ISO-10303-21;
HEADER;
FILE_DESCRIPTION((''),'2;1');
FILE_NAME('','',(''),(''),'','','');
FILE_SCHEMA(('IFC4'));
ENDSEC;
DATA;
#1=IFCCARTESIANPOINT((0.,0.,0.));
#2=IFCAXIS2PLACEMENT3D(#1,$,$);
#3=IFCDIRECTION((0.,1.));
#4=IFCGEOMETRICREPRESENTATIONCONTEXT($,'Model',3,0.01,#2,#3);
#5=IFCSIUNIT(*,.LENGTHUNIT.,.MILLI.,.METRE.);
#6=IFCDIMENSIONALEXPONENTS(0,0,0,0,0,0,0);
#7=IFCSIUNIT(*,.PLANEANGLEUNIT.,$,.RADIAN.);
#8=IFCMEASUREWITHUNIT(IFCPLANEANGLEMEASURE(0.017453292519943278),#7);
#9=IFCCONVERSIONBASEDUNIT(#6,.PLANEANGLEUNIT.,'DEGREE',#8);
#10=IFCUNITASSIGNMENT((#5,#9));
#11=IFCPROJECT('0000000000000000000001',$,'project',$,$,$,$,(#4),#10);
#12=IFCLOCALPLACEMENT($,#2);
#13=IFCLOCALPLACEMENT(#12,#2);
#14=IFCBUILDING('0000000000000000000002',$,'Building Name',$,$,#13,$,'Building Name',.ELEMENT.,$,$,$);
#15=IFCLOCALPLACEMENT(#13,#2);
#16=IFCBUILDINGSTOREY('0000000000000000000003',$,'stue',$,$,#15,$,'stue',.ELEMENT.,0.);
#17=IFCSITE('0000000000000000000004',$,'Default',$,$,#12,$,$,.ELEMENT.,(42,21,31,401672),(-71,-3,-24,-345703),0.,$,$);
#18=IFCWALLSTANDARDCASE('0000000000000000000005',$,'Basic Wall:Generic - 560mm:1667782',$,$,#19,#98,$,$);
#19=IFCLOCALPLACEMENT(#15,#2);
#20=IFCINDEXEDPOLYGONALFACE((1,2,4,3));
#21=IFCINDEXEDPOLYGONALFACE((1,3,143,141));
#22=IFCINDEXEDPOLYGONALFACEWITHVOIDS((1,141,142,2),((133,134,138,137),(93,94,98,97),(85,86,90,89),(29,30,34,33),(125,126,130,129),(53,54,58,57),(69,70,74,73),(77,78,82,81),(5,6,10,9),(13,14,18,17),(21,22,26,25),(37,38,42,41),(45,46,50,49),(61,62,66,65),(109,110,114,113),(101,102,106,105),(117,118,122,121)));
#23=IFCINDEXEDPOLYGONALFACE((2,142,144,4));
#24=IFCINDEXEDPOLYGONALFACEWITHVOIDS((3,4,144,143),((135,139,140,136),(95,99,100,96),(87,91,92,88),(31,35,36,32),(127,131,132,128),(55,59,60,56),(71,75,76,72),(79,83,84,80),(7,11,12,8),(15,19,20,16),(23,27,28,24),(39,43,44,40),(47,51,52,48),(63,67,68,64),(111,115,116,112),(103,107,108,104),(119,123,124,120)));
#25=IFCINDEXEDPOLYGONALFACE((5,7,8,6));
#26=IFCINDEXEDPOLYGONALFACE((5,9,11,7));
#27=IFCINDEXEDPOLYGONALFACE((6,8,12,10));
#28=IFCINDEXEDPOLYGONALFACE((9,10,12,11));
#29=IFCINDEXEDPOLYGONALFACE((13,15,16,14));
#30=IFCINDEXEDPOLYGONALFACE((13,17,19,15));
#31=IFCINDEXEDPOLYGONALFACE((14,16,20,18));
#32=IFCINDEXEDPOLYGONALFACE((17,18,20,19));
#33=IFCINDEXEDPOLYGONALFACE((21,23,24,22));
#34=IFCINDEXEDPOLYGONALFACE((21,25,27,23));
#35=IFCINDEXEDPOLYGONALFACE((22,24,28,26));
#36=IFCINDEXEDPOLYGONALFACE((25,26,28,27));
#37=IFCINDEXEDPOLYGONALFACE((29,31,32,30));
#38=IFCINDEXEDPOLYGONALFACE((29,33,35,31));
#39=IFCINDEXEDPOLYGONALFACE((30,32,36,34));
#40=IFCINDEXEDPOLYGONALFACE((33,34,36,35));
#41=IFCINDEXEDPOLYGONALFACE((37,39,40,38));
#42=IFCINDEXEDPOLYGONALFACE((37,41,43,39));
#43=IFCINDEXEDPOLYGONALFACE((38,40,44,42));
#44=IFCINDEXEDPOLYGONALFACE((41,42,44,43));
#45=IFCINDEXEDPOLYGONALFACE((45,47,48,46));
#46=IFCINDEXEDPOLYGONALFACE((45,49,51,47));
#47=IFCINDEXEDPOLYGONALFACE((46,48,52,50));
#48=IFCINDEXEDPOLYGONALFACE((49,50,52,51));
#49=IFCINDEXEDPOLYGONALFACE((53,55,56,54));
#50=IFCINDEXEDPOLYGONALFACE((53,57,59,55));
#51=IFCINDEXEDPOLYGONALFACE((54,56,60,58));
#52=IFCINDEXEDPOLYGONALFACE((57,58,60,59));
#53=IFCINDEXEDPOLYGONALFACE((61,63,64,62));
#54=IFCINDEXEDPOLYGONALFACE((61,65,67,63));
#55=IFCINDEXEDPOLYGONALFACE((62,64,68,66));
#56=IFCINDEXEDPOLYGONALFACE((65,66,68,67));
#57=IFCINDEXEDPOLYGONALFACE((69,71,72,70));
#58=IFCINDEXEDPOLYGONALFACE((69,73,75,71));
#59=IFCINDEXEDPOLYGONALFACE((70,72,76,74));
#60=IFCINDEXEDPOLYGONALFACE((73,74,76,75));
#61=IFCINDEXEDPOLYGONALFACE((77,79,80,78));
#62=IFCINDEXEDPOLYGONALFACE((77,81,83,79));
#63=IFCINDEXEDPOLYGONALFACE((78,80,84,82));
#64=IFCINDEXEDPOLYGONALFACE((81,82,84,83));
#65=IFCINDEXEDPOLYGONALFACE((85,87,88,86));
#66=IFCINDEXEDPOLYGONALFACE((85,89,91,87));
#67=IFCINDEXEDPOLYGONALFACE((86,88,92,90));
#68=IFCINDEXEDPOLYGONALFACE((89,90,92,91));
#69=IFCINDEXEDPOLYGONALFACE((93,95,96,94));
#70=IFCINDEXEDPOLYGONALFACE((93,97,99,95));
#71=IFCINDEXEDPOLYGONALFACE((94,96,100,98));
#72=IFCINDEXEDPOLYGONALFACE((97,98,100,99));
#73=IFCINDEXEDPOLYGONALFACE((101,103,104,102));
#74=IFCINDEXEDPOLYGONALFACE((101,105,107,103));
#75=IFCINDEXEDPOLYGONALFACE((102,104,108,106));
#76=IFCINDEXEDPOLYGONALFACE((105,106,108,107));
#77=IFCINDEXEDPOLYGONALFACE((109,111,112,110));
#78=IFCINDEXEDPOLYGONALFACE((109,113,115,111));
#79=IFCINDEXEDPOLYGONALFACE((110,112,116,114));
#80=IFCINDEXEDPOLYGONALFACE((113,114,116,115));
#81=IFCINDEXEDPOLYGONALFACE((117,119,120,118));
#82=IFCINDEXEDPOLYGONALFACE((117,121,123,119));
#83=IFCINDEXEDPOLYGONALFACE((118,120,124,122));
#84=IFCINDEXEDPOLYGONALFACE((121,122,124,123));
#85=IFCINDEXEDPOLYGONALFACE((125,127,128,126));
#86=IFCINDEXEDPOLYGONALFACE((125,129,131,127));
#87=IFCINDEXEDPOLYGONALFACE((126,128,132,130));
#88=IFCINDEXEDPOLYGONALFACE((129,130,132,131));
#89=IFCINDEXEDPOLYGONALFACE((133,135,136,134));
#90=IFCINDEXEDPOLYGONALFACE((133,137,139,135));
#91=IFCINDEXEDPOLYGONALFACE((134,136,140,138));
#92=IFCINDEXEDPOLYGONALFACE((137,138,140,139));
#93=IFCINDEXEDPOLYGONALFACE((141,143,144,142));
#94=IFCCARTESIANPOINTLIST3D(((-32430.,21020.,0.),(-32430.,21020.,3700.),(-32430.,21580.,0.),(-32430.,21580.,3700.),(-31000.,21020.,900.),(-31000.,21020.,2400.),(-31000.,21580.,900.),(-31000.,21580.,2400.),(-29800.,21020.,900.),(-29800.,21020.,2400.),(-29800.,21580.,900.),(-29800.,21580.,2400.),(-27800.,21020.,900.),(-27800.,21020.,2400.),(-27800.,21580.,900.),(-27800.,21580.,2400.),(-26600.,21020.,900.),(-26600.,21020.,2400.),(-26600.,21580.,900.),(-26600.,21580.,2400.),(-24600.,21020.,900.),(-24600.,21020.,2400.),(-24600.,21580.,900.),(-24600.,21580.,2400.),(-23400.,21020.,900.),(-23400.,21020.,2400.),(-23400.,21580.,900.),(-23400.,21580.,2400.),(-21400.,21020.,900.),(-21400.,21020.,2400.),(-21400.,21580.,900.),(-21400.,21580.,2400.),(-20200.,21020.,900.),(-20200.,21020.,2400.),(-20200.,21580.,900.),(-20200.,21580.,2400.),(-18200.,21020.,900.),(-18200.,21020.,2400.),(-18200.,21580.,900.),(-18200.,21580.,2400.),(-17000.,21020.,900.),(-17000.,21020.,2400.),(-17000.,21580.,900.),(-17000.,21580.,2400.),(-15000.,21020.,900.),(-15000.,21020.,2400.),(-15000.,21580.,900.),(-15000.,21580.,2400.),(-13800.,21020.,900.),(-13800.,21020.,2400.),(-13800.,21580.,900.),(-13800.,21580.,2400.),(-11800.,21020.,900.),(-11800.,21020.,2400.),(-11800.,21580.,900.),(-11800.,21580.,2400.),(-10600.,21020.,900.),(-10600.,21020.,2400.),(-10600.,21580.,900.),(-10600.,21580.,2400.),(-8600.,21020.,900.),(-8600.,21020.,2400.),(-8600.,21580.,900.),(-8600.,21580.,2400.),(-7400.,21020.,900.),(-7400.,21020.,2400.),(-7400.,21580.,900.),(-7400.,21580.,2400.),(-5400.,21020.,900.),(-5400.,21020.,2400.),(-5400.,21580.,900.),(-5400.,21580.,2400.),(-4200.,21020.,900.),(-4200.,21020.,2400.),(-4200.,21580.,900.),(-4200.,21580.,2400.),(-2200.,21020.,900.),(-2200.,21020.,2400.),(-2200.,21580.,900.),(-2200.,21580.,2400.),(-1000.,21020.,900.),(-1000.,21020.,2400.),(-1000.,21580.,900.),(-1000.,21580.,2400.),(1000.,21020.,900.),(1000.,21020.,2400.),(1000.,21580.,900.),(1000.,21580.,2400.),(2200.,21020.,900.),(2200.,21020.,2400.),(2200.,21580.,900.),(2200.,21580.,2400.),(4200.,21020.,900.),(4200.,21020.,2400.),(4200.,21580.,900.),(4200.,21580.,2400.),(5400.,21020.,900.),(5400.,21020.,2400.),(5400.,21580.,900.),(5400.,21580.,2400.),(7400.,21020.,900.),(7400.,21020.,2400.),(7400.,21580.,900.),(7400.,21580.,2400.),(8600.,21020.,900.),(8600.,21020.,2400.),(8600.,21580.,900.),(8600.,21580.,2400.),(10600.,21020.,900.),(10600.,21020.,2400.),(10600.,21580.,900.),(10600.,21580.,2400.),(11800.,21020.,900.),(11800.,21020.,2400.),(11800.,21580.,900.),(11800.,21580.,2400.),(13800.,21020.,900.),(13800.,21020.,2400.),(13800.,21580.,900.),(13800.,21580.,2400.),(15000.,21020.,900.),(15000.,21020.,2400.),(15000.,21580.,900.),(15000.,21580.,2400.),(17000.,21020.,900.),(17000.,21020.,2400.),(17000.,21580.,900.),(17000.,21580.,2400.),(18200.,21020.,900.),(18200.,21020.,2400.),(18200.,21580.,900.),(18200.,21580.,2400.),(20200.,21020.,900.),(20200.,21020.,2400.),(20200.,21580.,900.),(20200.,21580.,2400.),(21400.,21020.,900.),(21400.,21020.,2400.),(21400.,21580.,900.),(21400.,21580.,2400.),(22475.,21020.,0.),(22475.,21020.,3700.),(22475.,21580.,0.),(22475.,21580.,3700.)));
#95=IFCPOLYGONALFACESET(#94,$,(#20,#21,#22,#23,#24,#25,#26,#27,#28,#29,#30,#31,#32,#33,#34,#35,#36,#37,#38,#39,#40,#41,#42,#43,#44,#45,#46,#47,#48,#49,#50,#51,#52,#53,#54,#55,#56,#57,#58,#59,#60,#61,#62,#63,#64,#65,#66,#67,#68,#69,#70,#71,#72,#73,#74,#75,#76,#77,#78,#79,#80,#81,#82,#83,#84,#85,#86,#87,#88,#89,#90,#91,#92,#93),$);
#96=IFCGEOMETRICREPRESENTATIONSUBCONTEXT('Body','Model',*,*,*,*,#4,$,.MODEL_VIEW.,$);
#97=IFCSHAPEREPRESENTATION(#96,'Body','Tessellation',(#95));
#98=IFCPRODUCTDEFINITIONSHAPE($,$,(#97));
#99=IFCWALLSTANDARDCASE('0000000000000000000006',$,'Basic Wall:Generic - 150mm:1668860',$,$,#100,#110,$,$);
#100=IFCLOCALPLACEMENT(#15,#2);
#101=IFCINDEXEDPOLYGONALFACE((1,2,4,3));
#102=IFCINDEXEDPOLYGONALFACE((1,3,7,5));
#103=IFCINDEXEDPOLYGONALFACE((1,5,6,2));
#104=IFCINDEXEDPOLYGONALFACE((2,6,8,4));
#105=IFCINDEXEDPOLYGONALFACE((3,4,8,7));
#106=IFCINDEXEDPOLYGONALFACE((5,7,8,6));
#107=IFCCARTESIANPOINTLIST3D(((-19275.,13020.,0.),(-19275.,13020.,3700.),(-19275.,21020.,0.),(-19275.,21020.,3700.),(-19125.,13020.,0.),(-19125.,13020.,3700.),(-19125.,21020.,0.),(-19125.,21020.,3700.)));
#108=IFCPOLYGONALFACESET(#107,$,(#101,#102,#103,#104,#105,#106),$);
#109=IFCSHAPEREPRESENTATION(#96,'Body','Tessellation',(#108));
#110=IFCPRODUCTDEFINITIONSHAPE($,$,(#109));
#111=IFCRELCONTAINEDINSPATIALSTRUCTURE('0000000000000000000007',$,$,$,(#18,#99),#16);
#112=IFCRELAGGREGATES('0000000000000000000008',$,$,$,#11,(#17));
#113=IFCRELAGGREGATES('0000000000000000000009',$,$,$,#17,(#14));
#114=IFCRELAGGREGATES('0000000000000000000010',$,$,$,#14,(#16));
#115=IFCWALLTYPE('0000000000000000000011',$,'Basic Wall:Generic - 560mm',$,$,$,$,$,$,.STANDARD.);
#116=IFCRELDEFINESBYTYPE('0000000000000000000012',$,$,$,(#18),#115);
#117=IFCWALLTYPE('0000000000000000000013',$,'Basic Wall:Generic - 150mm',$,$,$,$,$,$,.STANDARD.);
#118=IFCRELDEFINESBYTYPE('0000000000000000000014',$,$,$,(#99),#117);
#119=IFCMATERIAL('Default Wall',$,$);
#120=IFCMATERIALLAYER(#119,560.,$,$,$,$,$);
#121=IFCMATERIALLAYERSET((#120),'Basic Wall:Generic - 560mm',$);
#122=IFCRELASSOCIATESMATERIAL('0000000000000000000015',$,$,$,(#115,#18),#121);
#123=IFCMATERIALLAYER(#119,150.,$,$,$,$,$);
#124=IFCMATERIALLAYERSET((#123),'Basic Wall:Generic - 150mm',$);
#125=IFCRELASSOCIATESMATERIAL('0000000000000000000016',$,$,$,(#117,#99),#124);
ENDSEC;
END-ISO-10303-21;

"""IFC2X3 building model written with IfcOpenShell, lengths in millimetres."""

from ifc_helpers import new_model, entity, si_unit, converted_unit, direction, frame, frame_2d, origin, place, context, subcontext, project, spatial, polyline, rectangle, extrude, clip, bounded_halfspace, material, layer, layer_set, layer_usage, type_object, element, save


model = new_model("IFC2X3")

# Units and contexts
model_context = context("Model", 3, precision=0.01, world=origin(), true_north=direction((0.0, 1.0)))
body_context = subcontext(model_context, "Body", "Model", "MODEL_VIEW")
ifc_project = project(units=[si_unit("LENGTHUNIT", "METRE", prefix="MILLI"), converted_unit("PLANEANGLEUNIT", "DEGREE", entity("IfcPlaneAngleMeasure", 0.017453292519943278), si_unit("PLANEANGLEUNIT", "RADIAN"), dimensions=[0, 0, 0, 0, 0, 0, 0])], contexts=[model_context])

# Site, building, storey
site_placement = place(None, origin())
site = spatial("IfcSite", under=ifc_project, at=site_placement, Name="Default", CompositionType="ELEMENT", RefLatitude=(42, 21, 31, 401672), RefLongitude=(-71, -3, -24, -345703), RefElevation=0.0)
building_placement = place(site_placement, origin())
building = spatial("IfcBuilding", under=site, at=building_placement, Name="Building Name", LongName="Building Name", CompositionType="ELEMENT")
storey_placement = place(building_placement, origin())
storey = spatial("IfcBuildingStorey", under=building, at=storey_placement, Name="stue", LongName="stue", CompositionType="ELEMENT", Elevation=0.0)

# Wall, openings
ifc_material_1 = material(Name="Default Wall")
ifc_layer_1 = layer(ifc_material_1, 560.0)
ifc_layer_set_1 = layer_set([ifc_layer_1], Name="Basic Wall:Generic - 560mm")
ifc_layer_usage_1 = layer_usage(ifc_layer_set_1, "AXIS2", "NEGATIVE", 280.0)
wall_type_1 = type_object("IfcWallType", Name="Basic Wall:Generic - 560mm", PredefinedType="STANDARD", material=ifc_layer_set_1)
wall_1_placement = place(storey_placement, frame((-32430.0, 21300.0, 0.0)))
wall_1 = element("IfcWallStandardCase", 1, at=wall_1_placement, inside=storey, type_object=wall_type_1, material=ifc_layer_usage_1, Name="Basic Wall:Generic - 560mm:1667782", context=body_context, shape_type="Clipping", body=[
    clip(extrude(rectangle(XDim=54905.0, YDim=560.0, at=frame_2d((27452.5, 0.0), x_axis=(-1.0, 0.0))), origin(), (0.0, 0.0, 1.0), 3700.0), bounded_halfspace(frame((0.0, -280.0, 3700.0), z_axis=(0.0, 0.0, -1.0), x_axis=(0.0, -1.0, 0.0)), True, frame((0.0, -280.0, 3700.0)), polyline([(0.0, 0.0), (390.0, 0.0), (13155.0, 0.0), (13305.0, 0.0), (25955.0, 0.0), (26105.0, 0.0), (38755.0, 0.0), (38905.0, 0.0), (45155.0, 0.0), (45305.0, 0.0), (51555.0, 0.0), (51705.0, 0.0), (54755.0, 0.0), (54905.0, 0.0), (54905.0, 560.0), (0.0, 560.0), (0.0, 0.0)]))),
])
opening_1_placement = place(wall_1_placement, frame((52630.0, -280.0, 900.0)))
element("IfcOpeningElement", 2, at=opening_1_placement, cuts=wall_1, ObjectType="Opening", context=body_context, shape_type="SweptSolid", body=[
    extrude(rectangle(XDim=1500.0, YDim=1200.0, at=frame_2d((750.0, 600.0), x_axis=(-1.0, 0.0))), frame((0.0, 0.0, 0.0), z_axis=(0.0, 1.0, 0.0), x_axis=(0.0, 0.0, 1.0)), (0.0, 0.0, 1.0), 560.0),
])
opening_2_placement = place(wall_1_placement, frame((49430.0, -280.0, 900.0)))
element("IfcOpeningElement", 3, at=opening_2_placement, cuts=wall_1, ObjectType="Opening", context=body_context, shape_type="SweptSolid", body=[
    extrude(rectangle(XDim=1500.0, YDim=1200.0, at=frame_2d((750.0, 600.0), x_axis=(-1.0, 0.0))), frame((0.0, 0.0, 0.0), z_axis=(0.0, 1.0, 0.0), x_axis=(0.0, 0.0, 1.0)), (0.0, 0.0, 1.0), 560.0),
])
opening_3_placement = place(wall_1_placement, frame((46230.0, -280.0, 900.0)))
element("IfcOpeningElement", 4, at=opening_3_placement, cuts=wall_1, ObjectType="Opening", context=body_context, shape_type="SweptSolid", body=[
    extrude(rectangle(XDim=1500.0, YDim=1200.0, at=frame_2d((750.0, 600.0), x_axis=(-1.0, 0.0))), frame((0.0, 0.0, 0.0), z_axis=(0.0, 1.0, 0.0), x_axis=(0.0, 0.0, 1.0)), (0.0, 0.0, 1.0), 560.0),
])
opening_4_placement = place(wall_1_placement, frame((43030.0, -280.0, 900.0)))
element("IfcOpeningElement", 5, at=opening_4_placement, cuts=wall_1, ObjectType="Opening", context=body_context, shape_type="SweptSolid", body=[
    extrude(rectangle(XDim=1500.0, YDim=1200.0, at=frame_2d((750.0, 600.0), x_axis=(-1.0, 0.0))), frame((0.0, 0.0, 0.0), z_axis=(0.0, 1.0, 0.0), x_axis=(0.0, 0.0, 1.0)), (0.0, 0.0, 1.0), 560.0),
])
opening_5_placement = place(wall_1_placement, frame((39830.0, -280.0, 900.0)))
element("IfcOpeningElement", 6, at=opening_5_placement, cuts=wall_1, ObjectType="Opening", context=body_context, shape_type="SweptSolid", body=[
    extrude(rectangle(XDim=1500.0, YDim=1200.0, at=frame_2d((750.0, 600.0), x_axis=(-1.0, 0.0))), frame((0.0, 0.0, 0.0), z_axis=(0.0, 1.0, 0.0), x_axis=(0.0, 0.0, 1.0)), (0.0, 0.0, 1.0), 560.0),
])
opening_6_placement = place(wall_1_placement, frame((36630.0, -280.0, 900.0)))
element("IfcOpeningElement", 7, at=opening_6_placement, cuts=wall_1, ObjectType="Opening", context=body_context, shape_type="SweptSolid", body=[
    extrude(rectangle(XDim=1500.0, YDim=1200.0, at=frame_2d((750.0, 600.0), x_axis=(-1.0, 0.0))), frame((0.0, 0.0, 0.0), z_axis=(0.0, 1.0, 0.0), x_axis=(0.0, 0.0, 1.0)), (0.0, 0.0, 1.0), 560.0),
])
opening_7_placement = place(wall_1_placement, frame((33430.0, -280.0, 900.0)))
element("IfcOpeningElement", 8, at=opening_7_placement, cuts=wall_1, ObjectType="Opening", context=body_context, shape_type="SweptSolid", body=[
    extrude(rectangle(XDim=1500.0, YDim=1200.0, at=frame_2d((750.0, 600.0), x_axis=(-1.0, 0.0))), frame((0.0, 0.0, 0.0), z_axis=(0.0, 1.0, 0.0), x_axis=(0.0, 0.0, 1.0)), (0.0, 0.0, 1.0), 560.0),
])
opening_8_placement = place(wall_1_placement, frame((30230.0, -280.0, 900.0)))
element("IfcOpeningElement", 9, at=opening_8_placement, cuts=wall_1, ObjectType="Opening", context=body_context, shape_type="SweptSolid", body=[
    extrude(rectangle(XDim=1500.0, YDim=1200.0, at=frame_2d((750.0, 600.0), x_axis=(-1.0, 0.0))), frame((0.0, 0.0, 0.0), z_axis=(0.0, 1.0, 0.0), x_axis=(0.0, 0.0, 1.0)), (0.0, 0.0, 1.0), 560.0),
])
opening_9_placement = place(wall_1_placement, frame((27030.0, -280.0, 900.0)))
element("IfcOpeningElement", 10, at=opening_9_placement, cuts=wall_1, ObjectType="Opening", context=body_context, shape_type="SweptSolid", body=[
    extrude(rectangle(XDim=1500.0, YDim=1200.0, at=frame_2d((750.0, 600.0), x_axis=(-1.0, 0.0))), frame((0.0, 0.0, 0.0), z_axis=(0.0, 1.0, 0.0), x_axis=(0.0, 0.0, 1.0)), (0.0, 0.0, 1.0), 560.0),
])
opening_10_placement = place(wall_1_placement, frame((23830.0, -280.0, 900.0)))
element("IfcOpeningElement", 11, at=opening_10_placement, cuts=wall_1, ObjectType="Opening", context=body_context, shape_type="SweptSolid", body=[
    extrude(rectangle(XDim=1500.0, YDim=1200.0, at=frame_2d((750.0, 600.0), x_axis=(-1.0, 0.0))), frame((0.0, 0.0, 0.0), z_axis=(0.0, 1.0, 0.0), x_axis=(0.0, 0.0, 1.0)), (0.0, 0.0, 1.0), 560.0),
])
opening_11_placement = place(wall_1_placement, frame((20630.0, -280.0, 900.0)))
element("IfcOpeningElement", 12, at=opening_11_placement, cuts=wall_1, ObjectType="Opening", context=body_context, shape_type="SweptSolid", body=[
    extrude(rectangle(XDim=1500.0, YDim=1200.0, at=frame_2d((750.0, 600.0), x_axis=(-1.0, 0.0))), frame((0.0, 0.0, 0.0), z_axis=(0.0, 1.0, 0.0), x_axis=(0.0, 0.0, 1.0)), (0.0, 0.0, 1.0), 560.0),
])
opening_12_placement = place(wall_1_placement, frame((17430.0, -280.0, 900.0)))
element("IfcOpeningElement", 13, at=opening_12_placement, cuts=wall_1, ObjectType="Opening", context=body_context, shape_type="SweptSolid", body=[
    extrude(rectangle(XDim=1500.0, YDim=1200.0, at=frame_2d((750.0, 600.0), x_axis=(-1.0, 0.0))), frame((0.0, 0.0, 0.0), z_axis=(0.0, 1.0, 0.0), x_axis=(0.0, 0.0, 1.0)), (0.0, 0.0, 1.0), 560.0),
])
opening_13_placement = place(wall_1_placement, frame((14230.0, -280.0, 900.0)))
element("IfcOpeningElement", 14, at=opening_13_placement, cuts=wall_1, ObjectType="Opening", context=body_context, shape_type="SweptSolid", body=[
    extrude(rectangle(XDim=1500.0, YDim=1200.0, at=frame_2d((750.0, 600.0), x_axis=(-1.0, 0.0))), frame((0.0, 0.0, 0.0), z_axis=(0.0, 1.0, 0.0), x_axis=(0.0, 0.0, 1.0)), (0.0, 0.0, 1.0), 560.0),
])
opening_14_placement = place(wall_1_placement, frame((11030.0, -280.0, 900.0)))
element("IfcOpeningElement", 15, at=opening_14_placement, cuts=wall_1, ObjectType="Opening", context=body_context, shape_type="SweptSolid", body=[
    extrude(rectangle(XDim=1500.0, YDim=1200.0, at=frame_2d((750.0, 600.0), x_axis=(-1.0, 0.0))), frame((0.0, 0.0, 0.0), z_axis=(0.0, 1.0, 0.0), x_axis=(0.0, 0.0, 1.0)), (0.0, 0.0, 1.0), 560.0),
])
opening_15_placement = place(wall_1_placement, frame((7830.0, -280.0, 900.0)))
element("IfcOpeningElement", 16, at=opening_15_placement, cuts=wall_1, ObjectType="Opening", context=body_context, shape_type="SweptSolid", body=[
    extrude(rectangle(XDim=1500.0, YDim=1200.0, at=frame_2d((750.0, 600.0), x_axis=(-1.0, 0.0))), frame((0.0, 0.0, 0.0), z_axis=(0.0, 1.0, 0.0), x_axis=(0.0, 0.0, 1.0)), (0.0, 0.0, 1.0), 560.0),
])
opening_16_placement = place(wall_1_placement, frame((4630.0, -280.0, 900.0)))
element("IfcOpeningElement", 17, at=opening_16_placement, cuts=wall_1, ObjectType="Opening", context=body_context, shape_type="SweptSolid", body=[
    extrude(rectangle(XDim=1500.0, YDim=1200.0, at=frame_2d((750.0, 600.0), x_axis=(-1.0, 0.0))), frame((0.0, 0.0, 0.0), z_axis=(0.0, 1.0, 0.0), x_axis=(0.0, 0.0, 1.0)), (0.0, 0.0, 1.0), 560.0),
])
opening_17_placement = place(wall_1_placement, frame((1430.0, -280.0, 900.0)))
element("IfcOpeningElement", 18, at=opening_17_placement, cuts=wall_1, ObjectType="Opening", context=body_context, shape_type="SweptSolid", body=[
    extrude(rectangle(XDim=1500.0, YDim=1200.0, at=frame_2d((750.0, 600.0), x_axis=(-1.0, 0.0))), frame((0.0, 0.0, 0.0), z_axis=(0.0, 1.0, 0.0), x_axis=(0.0, 0.0, 1.0)), (0.0, 0.0, 1.0), 560.0),
])

# Wall
ifc_layer_2 = layer(ifc_material_1, 150.0)
ifc_layer_set_2 = layer_set([ifc_layer_2], Name="Basic Wall:Generic - 150mm")
ifc_layer_usage_2 = layer_usage(ifc_layer_set_2, "AXIS2", "NEGATIVE", 75.0)
wall_type_2 = type_object("IfcWallType", Name="Basic Wall:Generic - 150mm", PredefinedType="STANDARD", material=ifc_layer_set_2)
wall_2_placement = place(storey_placement, frame((-19200.0, 21020.0, 0.0), z_axis=(0.0, 0.0, 1.0), x_axis=(0.0, -1.0, 0.0)))
element("IfcWallStandardCase", 19, at=wall_2_placement, inside=storey, type_object=wall_type_2, material=ifc_layer_usage_2, Name="Basic Wall:Generic - 150mm:1668860", context=body_context, shape_type="Clipping", body=[
    clip(extrude(rectangle(XDim=8000.0, YDim=150.0, at=frame_2d((4000.0, 0.0), x_axis=(-1.0, 0.0))), origin(), (0.0, 0.0, 1.0), 3700.0), bounded_halfspace(frame((0.0, -75.0, 3700.0), z_axis=(0.0, 0.0, -1.0), x_axis=(1.0, 0.0, 0.0)), True, frame((0.0, -75.0, 3700.0)), polyline([(0.0, 0.0), (8000.0, 0.0), (8000.0, 150.0), (0.0, 150.0), (0.0, 0.0)]))),
])

save(model, "model.ifc")
